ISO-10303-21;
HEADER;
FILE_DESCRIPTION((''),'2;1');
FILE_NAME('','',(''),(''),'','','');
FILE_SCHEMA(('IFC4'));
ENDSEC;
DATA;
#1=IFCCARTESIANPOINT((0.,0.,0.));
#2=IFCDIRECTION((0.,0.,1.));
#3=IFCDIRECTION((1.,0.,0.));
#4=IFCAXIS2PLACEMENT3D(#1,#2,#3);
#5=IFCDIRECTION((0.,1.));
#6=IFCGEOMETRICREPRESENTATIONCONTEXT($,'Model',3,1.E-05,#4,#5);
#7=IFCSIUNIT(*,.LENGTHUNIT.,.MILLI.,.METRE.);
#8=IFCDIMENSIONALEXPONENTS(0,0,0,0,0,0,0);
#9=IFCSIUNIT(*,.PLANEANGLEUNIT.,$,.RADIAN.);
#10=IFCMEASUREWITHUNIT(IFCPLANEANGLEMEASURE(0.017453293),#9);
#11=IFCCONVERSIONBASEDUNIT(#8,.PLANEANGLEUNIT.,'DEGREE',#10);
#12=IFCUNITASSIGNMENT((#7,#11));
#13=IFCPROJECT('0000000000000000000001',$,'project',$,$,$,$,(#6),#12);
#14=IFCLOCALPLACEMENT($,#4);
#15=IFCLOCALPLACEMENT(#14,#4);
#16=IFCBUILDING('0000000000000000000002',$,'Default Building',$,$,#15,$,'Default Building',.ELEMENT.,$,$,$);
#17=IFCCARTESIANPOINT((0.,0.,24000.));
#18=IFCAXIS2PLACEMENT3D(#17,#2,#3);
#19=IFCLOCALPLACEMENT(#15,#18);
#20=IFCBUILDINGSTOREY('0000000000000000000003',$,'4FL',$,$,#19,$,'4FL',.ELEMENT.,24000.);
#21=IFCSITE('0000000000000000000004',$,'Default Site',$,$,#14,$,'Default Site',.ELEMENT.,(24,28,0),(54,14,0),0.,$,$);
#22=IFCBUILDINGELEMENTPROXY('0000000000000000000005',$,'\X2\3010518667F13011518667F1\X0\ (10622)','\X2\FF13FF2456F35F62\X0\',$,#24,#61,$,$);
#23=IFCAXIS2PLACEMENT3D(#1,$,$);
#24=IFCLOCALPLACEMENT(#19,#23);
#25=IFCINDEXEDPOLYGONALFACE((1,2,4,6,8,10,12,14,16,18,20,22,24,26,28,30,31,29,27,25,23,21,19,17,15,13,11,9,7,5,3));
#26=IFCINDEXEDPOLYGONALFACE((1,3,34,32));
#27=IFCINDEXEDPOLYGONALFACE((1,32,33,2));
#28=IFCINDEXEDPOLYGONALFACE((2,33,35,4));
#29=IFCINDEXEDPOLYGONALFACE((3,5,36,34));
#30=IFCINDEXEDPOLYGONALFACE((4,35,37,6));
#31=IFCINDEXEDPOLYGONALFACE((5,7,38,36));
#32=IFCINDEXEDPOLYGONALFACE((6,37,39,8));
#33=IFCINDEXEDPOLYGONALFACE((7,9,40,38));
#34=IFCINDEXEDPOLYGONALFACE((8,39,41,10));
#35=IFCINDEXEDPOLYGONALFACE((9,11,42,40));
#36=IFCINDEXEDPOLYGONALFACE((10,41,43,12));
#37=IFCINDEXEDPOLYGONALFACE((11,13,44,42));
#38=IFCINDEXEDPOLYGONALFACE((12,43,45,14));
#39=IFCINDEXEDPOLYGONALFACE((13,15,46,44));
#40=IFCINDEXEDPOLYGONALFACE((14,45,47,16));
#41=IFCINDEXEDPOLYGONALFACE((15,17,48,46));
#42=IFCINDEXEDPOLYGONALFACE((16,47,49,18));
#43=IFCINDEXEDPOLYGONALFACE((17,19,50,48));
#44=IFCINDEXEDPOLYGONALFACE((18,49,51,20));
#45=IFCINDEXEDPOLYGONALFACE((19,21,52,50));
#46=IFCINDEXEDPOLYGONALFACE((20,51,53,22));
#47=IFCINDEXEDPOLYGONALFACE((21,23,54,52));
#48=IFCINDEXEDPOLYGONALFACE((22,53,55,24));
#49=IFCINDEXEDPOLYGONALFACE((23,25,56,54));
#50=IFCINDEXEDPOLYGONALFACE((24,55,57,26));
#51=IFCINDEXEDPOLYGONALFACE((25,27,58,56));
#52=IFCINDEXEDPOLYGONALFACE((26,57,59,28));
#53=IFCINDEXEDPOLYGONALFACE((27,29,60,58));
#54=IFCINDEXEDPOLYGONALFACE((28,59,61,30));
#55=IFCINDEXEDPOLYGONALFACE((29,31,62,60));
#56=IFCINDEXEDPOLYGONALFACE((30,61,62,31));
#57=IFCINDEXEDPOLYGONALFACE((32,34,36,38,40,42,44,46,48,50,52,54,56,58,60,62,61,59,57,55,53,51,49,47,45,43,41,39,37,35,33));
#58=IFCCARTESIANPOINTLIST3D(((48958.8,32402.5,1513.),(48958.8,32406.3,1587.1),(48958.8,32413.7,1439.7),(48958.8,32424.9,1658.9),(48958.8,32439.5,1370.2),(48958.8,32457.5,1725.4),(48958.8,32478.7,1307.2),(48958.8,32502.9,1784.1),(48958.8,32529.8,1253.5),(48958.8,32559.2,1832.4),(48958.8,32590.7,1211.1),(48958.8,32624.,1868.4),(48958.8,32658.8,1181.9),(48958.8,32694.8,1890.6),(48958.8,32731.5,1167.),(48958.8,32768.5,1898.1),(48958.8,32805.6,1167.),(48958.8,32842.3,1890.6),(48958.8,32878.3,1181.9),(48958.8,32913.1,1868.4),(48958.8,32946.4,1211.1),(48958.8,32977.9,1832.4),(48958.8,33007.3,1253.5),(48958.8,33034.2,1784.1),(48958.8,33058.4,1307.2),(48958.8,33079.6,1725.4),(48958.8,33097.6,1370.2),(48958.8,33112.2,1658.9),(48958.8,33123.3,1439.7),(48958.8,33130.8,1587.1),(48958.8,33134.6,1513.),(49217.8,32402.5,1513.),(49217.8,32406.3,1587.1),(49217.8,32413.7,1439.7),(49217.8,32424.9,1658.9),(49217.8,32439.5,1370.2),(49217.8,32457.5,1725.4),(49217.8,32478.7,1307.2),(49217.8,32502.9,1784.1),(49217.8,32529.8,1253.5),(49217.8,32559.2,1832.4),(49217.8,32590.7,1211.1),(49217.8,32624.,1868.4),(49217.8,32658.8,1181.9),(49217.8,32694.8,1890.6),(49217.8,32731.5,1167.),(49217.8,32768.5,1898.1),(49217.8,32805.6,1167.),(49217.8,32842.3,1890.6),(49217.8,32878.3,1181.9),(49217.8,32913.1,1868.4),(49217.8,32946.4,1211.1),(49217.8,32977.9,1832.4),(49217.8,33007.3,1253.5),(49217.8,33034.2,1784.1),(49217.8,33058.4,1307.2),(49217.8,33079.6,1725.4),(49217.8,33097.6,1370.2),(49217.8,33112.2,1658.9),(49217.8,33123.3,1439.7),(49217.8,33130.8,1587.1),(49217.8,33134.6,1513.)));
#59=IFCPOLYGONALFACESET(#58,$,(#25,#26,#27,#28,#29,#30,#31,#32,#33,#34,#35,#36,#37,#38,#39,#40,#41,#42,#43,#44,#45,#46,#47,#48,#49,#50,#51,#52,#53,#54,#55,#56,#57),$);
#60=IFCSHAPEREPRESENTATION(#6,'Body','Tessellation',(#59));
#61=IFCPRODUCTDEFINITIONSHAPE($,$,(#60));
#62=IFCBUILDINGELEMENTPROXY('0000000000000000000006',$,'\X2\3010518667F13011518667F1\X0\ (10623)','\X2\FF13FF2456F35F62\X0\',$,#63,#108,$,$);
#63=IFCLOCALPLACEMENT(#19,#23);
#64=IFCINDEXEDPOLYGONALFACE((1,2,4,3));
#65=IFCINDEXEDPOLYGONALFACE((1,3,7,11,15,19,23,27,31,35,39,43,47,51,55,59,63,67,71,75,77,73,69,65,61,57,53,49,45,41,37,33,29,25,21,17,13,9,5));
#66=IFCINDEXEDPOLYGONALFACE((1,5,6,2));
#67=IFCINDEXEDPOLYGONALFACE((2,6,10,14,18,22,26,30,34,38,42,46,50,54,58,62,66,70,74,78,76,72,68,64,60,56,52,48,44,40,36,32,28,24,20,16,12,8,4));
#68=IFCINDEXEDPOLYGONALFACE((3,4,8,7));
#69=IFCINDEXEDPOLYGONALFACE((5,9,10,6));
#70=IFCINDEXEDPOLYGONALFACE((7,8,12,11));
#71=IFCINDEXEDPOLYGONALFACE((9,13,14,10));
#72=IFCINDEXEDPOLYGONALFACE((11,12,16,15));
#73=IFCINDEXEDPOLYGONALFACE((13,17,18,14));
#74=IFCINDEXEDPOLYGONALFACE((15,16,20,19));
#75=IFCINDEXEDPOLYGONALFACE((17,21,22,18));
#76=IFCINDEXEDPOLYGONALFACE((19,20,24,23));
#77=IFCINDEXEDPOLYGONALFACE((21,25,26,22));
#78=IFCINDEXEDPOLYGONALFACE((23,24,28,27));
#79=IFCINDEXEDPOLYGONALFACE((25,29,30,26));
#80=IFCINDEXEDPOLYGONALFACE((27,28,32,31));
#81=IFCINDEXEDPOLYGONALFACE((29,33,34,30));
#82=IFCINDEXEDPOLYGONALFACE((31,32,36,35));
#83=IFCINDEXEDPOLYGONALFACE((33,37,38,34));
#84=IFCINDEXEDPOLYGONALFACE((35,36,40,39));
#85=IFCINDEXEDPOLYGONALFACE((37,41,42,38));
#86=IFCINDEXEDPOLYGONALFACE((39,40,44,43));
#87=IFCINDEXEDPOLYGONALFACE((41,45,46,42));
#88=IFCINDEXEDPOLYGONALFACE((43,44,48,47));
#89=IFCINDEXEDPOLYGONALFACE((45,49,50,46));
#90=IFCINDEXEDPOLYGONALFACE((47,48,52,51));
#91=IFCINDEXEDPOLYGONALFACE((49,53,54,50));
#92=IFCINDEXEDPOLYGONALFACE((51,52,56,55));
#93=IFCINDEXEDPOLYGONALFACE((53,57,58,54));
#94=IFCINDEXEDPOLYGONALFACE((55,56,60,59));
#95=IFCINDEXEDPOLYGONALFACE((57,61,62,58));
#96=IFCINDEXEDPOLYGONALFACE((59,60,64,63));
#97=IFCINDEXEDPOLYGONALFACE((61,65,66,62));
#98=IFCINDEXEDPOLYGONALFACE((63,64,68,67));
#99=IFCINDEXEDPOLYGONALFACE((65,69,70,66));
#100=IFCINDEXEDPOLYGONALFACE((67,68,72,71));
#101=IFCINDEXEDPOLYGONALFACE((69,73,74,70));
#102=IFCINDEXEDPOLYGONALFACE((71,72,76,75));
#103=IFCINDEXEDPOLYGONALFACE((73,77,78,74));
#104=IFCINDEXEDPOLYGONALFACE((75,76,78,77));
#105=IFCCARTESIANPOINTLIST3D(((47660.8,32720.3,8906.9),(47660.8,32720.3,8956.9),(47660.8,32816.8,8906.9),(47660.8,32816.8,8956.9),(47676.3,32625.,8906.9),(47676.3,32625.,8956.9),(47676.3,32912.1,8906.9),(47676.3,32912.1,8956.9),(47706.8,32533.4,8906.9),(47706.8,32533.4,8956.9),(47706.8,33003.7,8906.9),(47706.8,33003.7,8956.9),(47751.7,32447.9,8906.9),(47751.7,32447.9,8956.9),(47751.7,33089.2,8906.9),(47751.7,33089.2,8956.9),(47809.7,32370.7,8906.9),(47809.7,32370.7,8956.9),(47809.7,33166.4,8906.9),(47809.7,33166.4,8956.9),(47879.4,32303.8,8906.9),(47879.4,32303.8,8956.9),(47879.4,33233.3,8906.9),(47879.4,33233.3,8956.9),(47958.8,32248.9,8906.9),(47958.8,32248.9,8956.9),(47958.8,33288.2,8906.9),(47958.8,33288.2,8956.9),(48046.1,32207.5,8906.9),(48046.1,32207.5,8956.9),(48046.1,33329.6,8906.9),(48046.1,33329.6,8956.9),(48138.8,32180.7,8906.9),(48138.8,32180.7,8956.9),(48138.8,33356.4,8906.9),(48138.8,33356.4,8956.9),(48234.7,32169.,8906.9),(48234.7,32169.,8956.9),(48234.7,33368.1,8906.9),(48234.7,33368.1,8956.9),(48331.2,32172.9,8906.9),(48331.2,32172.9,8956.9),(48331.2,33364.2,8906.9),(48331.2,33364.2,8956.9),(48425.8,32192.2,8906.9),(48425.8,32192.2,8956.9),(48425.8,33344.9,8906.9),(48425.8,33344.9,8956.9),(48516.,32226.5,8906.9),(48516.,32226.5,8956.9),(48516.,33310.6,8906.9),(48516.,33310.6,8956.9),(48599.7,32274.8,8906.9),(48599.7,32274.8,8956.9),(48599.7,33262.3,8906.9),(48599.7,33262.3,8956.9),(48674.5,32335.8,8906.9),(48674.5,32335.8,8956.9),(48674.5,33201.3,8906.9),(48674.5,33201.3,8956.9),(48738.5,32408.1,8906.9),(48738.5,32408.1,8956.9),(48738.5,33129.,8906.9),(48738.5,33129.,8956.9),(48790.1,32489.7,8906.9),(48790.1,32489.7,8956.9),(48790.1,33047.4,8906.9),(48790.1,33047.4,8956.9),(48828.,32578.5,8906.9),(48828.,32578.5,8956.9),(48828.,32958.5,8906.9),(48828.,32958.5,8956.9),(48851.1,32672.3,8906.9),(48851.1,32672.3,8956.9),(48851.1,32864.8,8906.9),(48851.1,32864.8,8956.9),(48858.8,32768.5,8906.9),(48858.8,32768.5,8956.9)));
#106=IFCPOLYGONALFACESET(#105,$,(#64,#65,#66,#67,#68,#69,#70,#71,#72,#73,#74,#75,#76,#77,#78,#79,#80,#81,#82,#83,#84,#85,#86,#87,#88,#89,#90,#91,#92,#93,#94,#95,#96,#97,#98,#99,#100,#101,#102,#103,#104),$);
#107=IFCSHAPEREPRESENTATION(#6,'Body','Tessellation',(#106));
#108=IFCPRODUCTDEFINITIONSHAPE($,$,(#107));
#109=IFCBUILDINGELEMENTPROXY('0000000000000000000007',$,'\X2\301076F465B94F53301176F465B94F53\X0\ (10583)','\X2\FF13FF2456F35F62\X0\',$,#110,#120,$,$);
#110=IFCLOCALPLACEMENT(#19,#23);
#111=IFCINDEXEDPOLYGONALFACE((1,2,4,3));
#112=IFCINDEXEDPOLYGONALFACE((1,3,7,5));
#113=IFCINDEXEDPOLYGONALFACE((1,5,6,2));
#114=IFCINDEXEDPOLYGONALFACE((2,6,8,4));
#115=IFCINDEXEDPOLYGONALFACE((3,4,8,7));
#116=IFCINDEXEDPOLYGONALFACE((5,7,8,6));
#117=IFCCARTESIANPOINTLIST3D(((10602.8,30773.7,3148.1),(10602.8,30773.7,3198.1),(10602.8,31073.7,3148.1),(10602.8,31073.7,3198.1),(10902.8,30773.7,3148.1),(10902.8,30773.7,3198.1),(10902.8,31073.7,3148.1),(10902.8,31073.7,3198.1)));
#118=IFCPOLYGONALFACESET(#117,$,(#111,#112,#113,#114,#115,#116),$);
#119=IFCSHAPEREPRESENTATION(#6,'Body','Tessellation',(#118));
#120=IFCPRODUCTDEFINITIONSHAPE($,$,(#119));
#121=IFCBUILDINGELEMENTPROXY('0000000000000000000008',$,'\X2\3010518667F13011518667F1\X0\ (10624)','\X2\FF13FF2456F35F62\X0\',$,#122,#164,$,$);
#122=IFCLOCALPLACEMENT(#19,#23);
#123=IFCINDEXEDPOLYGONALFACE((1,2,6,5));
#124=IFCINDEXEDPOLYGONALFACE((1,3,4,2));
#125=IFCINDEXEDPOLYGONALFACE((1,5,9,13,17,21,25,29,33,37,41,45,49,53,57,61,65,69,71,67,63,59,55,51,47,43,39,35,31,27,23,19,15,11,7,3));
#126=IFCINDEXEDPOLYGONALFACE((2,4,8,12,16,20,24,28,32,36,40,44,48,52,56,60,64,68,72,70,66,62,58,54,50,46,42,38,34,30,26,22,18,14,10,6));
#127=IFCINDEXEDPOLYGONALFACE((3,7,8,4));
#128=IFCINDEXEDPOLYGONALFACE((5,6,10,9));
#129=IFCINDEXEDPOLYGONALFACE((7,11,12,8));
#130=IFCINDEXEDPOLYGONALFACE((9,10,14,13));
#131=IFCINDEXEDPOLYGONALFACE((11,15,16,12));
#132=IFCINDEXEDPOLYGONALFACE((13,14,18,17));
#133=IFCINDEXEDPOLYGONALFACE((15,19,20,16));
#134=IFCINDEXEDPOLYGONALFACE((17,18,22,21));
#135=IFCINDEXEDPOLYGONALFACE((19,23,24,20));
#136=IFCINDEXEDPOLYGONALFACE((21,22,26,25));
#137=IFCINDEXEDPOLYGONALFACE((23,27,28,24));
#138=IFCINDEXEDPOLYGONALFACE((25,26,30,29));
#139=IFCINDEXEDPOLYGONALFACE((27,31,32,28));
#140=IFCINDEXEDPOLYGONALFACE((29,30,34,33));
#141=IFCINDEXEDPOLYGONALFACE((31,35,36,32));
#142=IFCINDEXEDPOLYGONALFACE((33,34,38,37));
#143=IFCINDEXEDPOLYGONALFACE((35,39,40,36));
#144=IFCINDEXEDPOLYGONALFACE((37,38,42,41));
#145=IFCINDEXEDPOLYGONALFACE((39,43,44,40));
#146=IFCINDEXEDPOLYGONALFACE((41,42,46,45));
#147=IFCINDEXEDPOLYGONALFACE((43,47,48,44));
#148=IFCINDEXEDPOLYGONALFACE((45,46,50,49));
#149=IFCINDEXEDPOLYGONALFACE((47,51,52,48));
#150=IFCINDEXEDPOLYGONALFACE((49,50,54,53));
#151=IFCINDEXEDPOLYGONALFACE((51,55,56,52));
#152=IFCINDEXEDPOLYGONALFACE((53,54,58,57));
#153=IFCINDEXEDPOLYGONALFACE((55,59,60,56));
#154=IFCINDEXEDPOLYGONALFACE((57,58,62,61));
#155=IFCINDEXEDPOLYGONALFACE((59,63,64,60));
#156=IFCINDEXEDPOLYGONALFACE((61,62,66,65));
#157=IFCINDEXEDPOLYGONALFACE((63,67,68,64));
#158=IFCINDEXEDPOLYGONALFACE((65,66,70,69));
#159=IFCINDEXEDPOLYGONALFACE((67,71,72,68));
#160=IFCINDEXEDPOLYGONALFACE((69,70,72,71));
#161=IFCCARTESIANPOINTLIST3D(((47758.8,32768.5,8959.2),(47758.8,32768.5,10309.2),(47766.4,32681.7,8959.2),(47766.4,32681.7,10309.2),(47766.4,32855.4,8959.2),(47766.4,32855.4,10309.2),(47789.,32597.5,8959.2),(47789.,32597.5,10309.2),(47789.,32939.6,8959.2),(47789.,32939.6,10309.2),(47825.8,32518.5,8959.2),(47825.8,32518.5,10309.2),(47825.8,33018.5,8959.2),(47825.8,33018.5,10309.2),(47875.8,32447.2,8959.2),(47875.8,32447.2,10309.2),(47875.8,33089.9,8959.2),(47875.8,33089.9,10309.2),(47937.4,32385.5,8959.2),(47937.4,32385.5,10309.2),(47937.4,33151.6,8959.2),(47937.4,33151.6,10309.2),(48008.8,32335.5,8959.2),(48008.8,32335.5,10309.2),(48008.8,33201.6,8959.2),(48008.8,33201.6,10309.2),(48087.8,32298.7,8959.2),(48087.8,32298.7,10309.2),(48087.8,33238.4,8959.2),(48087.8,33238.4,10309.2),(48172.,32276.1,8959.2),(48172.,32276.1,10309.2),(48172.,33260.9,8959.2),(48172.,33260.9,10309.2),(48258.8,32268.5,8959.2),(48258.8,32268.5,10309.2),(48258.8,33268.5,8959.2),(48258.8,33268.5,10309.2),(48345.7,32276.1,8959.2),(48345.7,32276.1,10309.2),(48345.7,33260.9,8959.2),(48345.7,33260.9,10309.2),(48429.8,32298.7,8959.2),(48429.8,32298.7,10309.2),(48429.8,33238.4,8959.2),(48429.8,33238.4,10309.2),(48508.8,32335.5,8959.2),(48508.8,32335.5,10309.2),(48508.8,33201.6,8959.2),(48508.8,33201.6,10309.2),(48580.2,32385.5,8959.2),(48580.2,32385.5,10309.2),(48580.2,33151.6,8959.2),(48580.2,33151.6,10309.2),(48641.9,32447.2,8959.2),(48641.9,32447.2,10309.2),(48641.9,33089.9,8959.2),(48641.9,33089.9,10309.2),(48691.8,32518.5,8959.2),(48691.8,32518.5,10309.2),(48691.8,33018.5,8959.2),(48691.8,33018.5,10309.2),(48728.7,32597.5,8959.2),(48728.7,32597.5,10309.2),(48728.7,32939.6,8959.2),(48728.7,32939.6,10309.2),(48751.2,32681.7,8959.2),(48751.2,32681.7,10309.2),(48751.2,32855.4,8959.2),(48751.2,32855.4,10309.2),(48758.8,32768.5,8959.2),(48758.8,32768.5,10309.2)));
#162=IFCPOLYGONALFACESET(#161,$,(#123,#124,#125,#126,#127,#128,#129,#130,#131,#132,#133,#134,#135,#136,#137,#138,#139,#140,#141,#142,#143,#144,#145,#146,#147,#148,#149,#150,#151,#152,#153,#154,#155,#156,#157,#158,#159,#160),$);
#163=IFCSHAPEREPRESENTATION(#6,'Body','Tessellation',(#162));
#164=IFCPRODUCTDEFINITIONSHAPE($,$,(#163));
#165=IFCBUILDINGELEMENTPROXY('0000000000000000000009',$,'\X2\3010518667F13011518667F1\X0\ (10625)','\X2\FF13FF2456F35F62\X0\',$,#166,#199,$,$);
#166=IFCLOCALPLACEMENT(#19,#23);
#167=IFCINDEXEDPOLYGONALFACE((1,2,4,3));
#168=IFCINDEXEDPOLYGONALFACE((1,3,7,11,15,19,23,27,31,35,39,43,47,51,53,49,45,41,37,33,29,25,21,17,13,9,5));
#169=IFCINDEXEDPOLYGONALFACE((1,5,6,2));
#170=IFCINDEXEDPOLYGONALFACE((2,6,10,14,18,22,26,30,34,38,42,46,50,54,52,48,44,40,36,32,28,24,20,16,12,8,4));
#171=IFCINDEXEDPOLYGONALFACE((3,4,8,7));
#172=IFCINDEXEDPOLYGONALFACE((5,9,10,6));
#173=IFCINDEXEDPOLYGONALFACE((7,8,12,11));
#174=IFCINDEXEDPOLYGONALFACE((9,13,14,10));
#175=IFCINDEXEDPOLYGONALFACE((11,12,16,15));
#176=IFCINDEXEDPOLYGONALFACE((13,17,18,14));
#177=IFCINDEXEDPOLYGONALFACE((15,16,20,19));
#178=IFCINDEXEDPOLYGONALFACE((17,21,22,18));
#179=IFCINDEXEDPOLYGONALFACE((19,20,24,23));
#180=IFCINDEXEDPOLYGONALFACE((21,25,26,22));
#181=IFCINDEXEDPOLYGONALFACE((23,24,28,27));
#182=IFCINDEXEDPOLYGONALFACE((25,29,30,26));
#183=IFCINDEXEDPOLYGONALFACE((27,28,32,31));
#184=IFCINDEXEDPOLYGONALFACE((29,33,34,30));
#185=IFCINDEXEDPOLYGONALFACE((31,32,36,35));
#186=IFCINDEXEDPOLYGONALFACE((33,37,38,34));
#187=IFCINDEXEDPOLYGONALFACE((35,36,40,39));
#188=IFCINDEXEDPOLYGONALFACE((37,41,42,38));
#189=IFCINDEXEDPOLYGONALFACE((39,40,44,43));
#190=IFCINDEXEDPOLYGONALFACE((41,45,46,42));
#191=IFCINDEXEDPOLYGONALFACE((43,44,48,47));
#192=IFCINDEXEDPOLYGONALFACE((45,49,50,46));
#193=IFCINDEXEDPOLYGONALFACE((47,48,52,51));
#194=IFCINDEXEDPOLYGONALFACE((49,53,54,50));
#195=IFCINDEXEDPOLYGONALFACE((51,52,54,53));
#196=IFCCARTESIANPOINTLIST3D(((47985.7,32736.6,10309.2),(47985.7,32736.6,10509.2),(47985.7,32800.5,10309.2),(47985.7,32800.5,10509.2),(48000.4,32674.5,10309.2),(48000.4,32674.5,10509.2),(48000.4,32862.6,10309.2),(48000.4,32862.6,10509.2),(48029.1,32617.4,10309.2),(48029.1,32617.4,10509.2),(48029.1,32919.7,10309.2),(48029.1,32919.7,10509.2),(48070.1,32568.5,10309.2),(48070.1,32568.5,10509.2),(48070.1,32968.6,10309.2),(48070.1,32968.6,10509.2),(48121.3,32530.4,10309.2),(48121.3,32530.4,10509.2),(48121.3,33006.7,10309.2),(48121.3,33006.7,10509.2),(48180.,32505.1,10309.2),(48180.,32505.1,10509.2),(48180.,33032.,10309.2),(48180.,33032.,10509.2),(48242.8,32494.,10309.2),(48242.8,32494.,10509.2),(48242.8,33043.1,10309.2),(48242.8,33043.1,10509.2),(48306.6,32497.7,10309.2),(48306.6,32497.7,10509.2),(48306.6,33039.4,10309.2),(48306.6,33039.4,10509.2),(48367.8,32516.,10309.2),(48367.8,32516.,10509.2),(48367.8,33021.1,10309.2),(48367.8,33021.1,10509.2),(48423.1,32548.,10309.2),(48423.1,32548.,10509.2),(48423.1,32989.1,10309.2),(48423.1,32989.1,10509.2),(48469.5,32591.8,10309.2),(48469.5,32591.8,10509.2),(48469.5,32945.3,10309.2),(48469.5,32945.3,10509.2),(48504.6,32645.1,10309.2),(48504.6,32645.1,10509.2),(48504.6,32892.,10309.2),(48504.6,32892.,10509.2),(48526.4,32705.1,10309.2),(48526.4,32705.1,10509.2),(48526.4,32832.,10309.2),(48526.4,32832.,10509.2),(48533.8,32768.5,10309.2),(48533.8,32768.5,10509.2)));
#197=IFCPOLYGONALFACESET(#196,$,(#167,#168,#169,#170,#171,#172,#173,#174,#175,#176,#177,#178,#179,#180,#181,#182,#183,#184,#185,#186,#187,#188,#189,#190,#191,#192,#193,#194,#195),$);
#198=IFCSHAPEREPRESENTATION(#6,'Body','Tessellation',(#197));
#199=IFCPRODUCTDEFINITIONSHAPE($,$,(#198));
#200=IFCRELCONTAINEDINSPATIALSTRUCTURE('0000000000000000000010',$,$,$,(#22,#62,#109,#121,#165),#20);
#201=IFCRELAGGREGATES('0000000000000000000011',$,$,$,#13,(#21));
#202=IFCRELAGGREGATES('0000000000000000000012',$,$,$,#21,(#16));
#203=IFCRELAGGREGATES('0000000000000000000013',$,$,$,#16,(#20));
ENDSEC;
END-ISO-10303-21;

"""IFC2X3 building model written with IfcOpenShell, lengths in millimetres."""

from ifc_helpers import new_model, entity, si_unit, converted_unit, direction, frame, origin_with_axes, origin_2d_with_axis, place, context, project, spatial, rectangle, circle, extrude, source, transform, mapped, element, save


model = new_model("IFC2X3")

# Units and contexts
model_context = context("Model", 3, precision=1e-05, world=origin_with_axes(), true_north=direction((0.0, 1.0)))
ifc_project = project(units=[si_unit("LENGTHUNIT", "METRE", prefix="MILLI"), converted_unit("PLANEANGLEUNIT", "DEGREE", entity("IfcPlaneAngleMeasure", 0.017453293), si_unit("PLANEANGLEUNIT", "RADIAN"), dimensions=[0, 0, 0, 0, 0, 0, 0])], contexts=[model_context])

# Site, building, storey
site_placement = place(None, origin_with_axes())
site = spatial("IfcSite", under=ifc_project, at=site_placement, Name="Default Site", LongName="Default Site", CompositionType="ELEMENT", RefLatitude=(24, 28, 0), RefLongitude=(54, 14, 0), RefElevation=0.0)
building_placement = place(site_placement, origin_with_axes())
building = spatial("IfcBuilding", under=site, at=building_placement, Name="Default Building", LongName="Default Building", CompositionType="ELEMENT")
storey_placement = place(building_placement, frame((0.0, 0.0, 24000.0), z_axis=(0.0, 0.0, 1.0), x_axis=(1.0, 0.0, 0.0)))
storey = spatial("IfcBuildingStorey", under=building, at=storey_placement, Name="4FL", LongName="4FL", CompositionType="ELEMENT", Elevation=24000.0)

# Building element proxies
shared_shape_1 = source(origin_with_axes(), model_context, "Body", "SweptSolid", [
    extrude(circle(Radius=366.5, at=origin_2d_with_axis()), frame((0.0, 0.0, 0.0), z_axis=(0.0, 0.0, 1.0), x_axis=(1.0, 0.0, 0.0)), (0.0, 0.0, 1.0), 259.0),
])
proxy_1_placement = place(storey_placement, frame((48958.8, 32768.5, 1531.6), z_axis=(1.0, 0.0, 0.0), x_axis=(0.0, 0.0, 1.0)))
element("IfcBuildingElementProxy", 1, at=proxy_1_placement, inside=storey, Name="【円柱】円柱 (10622)", Description="３Ｄ図形", context=model_context, shape_type="MappedRepresentation", body=[
    mapped(shared_shape_1, transform((0.0, 0.0, 0.0))),
])
shared_shape_2 = source(origin_with_axes(), model_context, "Body", "SweptSolid", [
    extrude(circle(Radius=600.0, at=origin_2d_with_axis()), origin_with_axes(), (0.0, 0.0, 1.0), 50.0),
])
proxy_2_placement = place(storey_placement, frame((48258.8, 32768.5, 8906.9), z_axis=(0.0, 0.0, 1.0), x_axis=(1.0, 0.0, 0.0)))
element("IfcBuildingElementProxy", 2, at=proxy_2_placement, inside=storey, Name="【円柱】円柱 (10623)", Description="３Ｄ図形", context=model_context, shape_type="MappedRepresentation", body=[
    mapped(shared_shape_2, transform((0.0, 0.0, 0.0))),
])
shared_shape_3 = source(origin_with_axes(), model_context, "Body", "SweptSolid", [
    extrude(rectangle(XDim=300.0, YDim=300.0, at=origin_2d_with_axis()), origin_with_axes(), (0.0, 0.0, 1.0), 50.0),
])
proxy_3_placement = place(storey_placement, frame((10752.8, 30923.7, 3148.1), z_axis=(0.0, 0.0, 1.0), x_axis=(1.0, 0.0, 0.0)))
element("IfcBuildingElementProxy", 3, at=proxy_3_placement, inside=storey, Name="【直方体】直方体 (10583)", Description="３Ｄ図形", context=model_context, shape_type="MappedRepresentation", body=[
    mapped(shared_shape_3, transform((0.0, 0.0, 0.0))),
])
shared_shape_4 = source(origin_with_axes(), model_context, "Body", "SweptSolid", [
    extrude(circle(Radius=500.0, at=origin_2d_with_axis()), origin_with_axes(), (0.0, 0.0, 1.0), 1350.0),
])
proxy_4_placement = place(storey_placement, frame((48258.8, 32768.5, 8959.2), z_axis=(0.0, 0.0, 1.0), x_axis=(1.0, 0.0, 0.0)))
element("IfcBuildingElementProxy", 4, at=proxy_4_placement, inside=storey, Name="【円柱】円柱 (10624)", Description="３Ｄ図形", context=model_context, shape_type="MappedRepresentation", body=[
    mapped(shared_shape_4, transform((0.0, 0.0, 0.0))),
])
shared_shape_5 = source(origin_with_axes(), model_context, "Body", "SweptSolid", [
    extrude(circle(Radius=275.0, at=origin_2d_with_axis()), frame((0.0, 0.0, 0.0), z_axis=(0.0, 0.0, 1.0), x_axis=(1.0, 0.0, 0.0)), (0.0, 0.0, 1.0), 200.0),
])
proxy_5_placement = place(storey_placement, frame((48258.8, 32768.5, 10309.2), z_axis=(0.0, 0.0, 1.0), x_axis=(1.0, 0.0, 0.0)))
element("IfcBuildingElementProxy", 5, at=proxy_5_placement, inside=storey, Name="【円柱】円柱 (10625)", Description="３Ｄ図形", context=model_context, shape_type="MappedRepresentation", body=[
    mapped(shared_shape_5, transform((0.0, 0.0, 0.0))),
])

save(model, "model.ifc")
